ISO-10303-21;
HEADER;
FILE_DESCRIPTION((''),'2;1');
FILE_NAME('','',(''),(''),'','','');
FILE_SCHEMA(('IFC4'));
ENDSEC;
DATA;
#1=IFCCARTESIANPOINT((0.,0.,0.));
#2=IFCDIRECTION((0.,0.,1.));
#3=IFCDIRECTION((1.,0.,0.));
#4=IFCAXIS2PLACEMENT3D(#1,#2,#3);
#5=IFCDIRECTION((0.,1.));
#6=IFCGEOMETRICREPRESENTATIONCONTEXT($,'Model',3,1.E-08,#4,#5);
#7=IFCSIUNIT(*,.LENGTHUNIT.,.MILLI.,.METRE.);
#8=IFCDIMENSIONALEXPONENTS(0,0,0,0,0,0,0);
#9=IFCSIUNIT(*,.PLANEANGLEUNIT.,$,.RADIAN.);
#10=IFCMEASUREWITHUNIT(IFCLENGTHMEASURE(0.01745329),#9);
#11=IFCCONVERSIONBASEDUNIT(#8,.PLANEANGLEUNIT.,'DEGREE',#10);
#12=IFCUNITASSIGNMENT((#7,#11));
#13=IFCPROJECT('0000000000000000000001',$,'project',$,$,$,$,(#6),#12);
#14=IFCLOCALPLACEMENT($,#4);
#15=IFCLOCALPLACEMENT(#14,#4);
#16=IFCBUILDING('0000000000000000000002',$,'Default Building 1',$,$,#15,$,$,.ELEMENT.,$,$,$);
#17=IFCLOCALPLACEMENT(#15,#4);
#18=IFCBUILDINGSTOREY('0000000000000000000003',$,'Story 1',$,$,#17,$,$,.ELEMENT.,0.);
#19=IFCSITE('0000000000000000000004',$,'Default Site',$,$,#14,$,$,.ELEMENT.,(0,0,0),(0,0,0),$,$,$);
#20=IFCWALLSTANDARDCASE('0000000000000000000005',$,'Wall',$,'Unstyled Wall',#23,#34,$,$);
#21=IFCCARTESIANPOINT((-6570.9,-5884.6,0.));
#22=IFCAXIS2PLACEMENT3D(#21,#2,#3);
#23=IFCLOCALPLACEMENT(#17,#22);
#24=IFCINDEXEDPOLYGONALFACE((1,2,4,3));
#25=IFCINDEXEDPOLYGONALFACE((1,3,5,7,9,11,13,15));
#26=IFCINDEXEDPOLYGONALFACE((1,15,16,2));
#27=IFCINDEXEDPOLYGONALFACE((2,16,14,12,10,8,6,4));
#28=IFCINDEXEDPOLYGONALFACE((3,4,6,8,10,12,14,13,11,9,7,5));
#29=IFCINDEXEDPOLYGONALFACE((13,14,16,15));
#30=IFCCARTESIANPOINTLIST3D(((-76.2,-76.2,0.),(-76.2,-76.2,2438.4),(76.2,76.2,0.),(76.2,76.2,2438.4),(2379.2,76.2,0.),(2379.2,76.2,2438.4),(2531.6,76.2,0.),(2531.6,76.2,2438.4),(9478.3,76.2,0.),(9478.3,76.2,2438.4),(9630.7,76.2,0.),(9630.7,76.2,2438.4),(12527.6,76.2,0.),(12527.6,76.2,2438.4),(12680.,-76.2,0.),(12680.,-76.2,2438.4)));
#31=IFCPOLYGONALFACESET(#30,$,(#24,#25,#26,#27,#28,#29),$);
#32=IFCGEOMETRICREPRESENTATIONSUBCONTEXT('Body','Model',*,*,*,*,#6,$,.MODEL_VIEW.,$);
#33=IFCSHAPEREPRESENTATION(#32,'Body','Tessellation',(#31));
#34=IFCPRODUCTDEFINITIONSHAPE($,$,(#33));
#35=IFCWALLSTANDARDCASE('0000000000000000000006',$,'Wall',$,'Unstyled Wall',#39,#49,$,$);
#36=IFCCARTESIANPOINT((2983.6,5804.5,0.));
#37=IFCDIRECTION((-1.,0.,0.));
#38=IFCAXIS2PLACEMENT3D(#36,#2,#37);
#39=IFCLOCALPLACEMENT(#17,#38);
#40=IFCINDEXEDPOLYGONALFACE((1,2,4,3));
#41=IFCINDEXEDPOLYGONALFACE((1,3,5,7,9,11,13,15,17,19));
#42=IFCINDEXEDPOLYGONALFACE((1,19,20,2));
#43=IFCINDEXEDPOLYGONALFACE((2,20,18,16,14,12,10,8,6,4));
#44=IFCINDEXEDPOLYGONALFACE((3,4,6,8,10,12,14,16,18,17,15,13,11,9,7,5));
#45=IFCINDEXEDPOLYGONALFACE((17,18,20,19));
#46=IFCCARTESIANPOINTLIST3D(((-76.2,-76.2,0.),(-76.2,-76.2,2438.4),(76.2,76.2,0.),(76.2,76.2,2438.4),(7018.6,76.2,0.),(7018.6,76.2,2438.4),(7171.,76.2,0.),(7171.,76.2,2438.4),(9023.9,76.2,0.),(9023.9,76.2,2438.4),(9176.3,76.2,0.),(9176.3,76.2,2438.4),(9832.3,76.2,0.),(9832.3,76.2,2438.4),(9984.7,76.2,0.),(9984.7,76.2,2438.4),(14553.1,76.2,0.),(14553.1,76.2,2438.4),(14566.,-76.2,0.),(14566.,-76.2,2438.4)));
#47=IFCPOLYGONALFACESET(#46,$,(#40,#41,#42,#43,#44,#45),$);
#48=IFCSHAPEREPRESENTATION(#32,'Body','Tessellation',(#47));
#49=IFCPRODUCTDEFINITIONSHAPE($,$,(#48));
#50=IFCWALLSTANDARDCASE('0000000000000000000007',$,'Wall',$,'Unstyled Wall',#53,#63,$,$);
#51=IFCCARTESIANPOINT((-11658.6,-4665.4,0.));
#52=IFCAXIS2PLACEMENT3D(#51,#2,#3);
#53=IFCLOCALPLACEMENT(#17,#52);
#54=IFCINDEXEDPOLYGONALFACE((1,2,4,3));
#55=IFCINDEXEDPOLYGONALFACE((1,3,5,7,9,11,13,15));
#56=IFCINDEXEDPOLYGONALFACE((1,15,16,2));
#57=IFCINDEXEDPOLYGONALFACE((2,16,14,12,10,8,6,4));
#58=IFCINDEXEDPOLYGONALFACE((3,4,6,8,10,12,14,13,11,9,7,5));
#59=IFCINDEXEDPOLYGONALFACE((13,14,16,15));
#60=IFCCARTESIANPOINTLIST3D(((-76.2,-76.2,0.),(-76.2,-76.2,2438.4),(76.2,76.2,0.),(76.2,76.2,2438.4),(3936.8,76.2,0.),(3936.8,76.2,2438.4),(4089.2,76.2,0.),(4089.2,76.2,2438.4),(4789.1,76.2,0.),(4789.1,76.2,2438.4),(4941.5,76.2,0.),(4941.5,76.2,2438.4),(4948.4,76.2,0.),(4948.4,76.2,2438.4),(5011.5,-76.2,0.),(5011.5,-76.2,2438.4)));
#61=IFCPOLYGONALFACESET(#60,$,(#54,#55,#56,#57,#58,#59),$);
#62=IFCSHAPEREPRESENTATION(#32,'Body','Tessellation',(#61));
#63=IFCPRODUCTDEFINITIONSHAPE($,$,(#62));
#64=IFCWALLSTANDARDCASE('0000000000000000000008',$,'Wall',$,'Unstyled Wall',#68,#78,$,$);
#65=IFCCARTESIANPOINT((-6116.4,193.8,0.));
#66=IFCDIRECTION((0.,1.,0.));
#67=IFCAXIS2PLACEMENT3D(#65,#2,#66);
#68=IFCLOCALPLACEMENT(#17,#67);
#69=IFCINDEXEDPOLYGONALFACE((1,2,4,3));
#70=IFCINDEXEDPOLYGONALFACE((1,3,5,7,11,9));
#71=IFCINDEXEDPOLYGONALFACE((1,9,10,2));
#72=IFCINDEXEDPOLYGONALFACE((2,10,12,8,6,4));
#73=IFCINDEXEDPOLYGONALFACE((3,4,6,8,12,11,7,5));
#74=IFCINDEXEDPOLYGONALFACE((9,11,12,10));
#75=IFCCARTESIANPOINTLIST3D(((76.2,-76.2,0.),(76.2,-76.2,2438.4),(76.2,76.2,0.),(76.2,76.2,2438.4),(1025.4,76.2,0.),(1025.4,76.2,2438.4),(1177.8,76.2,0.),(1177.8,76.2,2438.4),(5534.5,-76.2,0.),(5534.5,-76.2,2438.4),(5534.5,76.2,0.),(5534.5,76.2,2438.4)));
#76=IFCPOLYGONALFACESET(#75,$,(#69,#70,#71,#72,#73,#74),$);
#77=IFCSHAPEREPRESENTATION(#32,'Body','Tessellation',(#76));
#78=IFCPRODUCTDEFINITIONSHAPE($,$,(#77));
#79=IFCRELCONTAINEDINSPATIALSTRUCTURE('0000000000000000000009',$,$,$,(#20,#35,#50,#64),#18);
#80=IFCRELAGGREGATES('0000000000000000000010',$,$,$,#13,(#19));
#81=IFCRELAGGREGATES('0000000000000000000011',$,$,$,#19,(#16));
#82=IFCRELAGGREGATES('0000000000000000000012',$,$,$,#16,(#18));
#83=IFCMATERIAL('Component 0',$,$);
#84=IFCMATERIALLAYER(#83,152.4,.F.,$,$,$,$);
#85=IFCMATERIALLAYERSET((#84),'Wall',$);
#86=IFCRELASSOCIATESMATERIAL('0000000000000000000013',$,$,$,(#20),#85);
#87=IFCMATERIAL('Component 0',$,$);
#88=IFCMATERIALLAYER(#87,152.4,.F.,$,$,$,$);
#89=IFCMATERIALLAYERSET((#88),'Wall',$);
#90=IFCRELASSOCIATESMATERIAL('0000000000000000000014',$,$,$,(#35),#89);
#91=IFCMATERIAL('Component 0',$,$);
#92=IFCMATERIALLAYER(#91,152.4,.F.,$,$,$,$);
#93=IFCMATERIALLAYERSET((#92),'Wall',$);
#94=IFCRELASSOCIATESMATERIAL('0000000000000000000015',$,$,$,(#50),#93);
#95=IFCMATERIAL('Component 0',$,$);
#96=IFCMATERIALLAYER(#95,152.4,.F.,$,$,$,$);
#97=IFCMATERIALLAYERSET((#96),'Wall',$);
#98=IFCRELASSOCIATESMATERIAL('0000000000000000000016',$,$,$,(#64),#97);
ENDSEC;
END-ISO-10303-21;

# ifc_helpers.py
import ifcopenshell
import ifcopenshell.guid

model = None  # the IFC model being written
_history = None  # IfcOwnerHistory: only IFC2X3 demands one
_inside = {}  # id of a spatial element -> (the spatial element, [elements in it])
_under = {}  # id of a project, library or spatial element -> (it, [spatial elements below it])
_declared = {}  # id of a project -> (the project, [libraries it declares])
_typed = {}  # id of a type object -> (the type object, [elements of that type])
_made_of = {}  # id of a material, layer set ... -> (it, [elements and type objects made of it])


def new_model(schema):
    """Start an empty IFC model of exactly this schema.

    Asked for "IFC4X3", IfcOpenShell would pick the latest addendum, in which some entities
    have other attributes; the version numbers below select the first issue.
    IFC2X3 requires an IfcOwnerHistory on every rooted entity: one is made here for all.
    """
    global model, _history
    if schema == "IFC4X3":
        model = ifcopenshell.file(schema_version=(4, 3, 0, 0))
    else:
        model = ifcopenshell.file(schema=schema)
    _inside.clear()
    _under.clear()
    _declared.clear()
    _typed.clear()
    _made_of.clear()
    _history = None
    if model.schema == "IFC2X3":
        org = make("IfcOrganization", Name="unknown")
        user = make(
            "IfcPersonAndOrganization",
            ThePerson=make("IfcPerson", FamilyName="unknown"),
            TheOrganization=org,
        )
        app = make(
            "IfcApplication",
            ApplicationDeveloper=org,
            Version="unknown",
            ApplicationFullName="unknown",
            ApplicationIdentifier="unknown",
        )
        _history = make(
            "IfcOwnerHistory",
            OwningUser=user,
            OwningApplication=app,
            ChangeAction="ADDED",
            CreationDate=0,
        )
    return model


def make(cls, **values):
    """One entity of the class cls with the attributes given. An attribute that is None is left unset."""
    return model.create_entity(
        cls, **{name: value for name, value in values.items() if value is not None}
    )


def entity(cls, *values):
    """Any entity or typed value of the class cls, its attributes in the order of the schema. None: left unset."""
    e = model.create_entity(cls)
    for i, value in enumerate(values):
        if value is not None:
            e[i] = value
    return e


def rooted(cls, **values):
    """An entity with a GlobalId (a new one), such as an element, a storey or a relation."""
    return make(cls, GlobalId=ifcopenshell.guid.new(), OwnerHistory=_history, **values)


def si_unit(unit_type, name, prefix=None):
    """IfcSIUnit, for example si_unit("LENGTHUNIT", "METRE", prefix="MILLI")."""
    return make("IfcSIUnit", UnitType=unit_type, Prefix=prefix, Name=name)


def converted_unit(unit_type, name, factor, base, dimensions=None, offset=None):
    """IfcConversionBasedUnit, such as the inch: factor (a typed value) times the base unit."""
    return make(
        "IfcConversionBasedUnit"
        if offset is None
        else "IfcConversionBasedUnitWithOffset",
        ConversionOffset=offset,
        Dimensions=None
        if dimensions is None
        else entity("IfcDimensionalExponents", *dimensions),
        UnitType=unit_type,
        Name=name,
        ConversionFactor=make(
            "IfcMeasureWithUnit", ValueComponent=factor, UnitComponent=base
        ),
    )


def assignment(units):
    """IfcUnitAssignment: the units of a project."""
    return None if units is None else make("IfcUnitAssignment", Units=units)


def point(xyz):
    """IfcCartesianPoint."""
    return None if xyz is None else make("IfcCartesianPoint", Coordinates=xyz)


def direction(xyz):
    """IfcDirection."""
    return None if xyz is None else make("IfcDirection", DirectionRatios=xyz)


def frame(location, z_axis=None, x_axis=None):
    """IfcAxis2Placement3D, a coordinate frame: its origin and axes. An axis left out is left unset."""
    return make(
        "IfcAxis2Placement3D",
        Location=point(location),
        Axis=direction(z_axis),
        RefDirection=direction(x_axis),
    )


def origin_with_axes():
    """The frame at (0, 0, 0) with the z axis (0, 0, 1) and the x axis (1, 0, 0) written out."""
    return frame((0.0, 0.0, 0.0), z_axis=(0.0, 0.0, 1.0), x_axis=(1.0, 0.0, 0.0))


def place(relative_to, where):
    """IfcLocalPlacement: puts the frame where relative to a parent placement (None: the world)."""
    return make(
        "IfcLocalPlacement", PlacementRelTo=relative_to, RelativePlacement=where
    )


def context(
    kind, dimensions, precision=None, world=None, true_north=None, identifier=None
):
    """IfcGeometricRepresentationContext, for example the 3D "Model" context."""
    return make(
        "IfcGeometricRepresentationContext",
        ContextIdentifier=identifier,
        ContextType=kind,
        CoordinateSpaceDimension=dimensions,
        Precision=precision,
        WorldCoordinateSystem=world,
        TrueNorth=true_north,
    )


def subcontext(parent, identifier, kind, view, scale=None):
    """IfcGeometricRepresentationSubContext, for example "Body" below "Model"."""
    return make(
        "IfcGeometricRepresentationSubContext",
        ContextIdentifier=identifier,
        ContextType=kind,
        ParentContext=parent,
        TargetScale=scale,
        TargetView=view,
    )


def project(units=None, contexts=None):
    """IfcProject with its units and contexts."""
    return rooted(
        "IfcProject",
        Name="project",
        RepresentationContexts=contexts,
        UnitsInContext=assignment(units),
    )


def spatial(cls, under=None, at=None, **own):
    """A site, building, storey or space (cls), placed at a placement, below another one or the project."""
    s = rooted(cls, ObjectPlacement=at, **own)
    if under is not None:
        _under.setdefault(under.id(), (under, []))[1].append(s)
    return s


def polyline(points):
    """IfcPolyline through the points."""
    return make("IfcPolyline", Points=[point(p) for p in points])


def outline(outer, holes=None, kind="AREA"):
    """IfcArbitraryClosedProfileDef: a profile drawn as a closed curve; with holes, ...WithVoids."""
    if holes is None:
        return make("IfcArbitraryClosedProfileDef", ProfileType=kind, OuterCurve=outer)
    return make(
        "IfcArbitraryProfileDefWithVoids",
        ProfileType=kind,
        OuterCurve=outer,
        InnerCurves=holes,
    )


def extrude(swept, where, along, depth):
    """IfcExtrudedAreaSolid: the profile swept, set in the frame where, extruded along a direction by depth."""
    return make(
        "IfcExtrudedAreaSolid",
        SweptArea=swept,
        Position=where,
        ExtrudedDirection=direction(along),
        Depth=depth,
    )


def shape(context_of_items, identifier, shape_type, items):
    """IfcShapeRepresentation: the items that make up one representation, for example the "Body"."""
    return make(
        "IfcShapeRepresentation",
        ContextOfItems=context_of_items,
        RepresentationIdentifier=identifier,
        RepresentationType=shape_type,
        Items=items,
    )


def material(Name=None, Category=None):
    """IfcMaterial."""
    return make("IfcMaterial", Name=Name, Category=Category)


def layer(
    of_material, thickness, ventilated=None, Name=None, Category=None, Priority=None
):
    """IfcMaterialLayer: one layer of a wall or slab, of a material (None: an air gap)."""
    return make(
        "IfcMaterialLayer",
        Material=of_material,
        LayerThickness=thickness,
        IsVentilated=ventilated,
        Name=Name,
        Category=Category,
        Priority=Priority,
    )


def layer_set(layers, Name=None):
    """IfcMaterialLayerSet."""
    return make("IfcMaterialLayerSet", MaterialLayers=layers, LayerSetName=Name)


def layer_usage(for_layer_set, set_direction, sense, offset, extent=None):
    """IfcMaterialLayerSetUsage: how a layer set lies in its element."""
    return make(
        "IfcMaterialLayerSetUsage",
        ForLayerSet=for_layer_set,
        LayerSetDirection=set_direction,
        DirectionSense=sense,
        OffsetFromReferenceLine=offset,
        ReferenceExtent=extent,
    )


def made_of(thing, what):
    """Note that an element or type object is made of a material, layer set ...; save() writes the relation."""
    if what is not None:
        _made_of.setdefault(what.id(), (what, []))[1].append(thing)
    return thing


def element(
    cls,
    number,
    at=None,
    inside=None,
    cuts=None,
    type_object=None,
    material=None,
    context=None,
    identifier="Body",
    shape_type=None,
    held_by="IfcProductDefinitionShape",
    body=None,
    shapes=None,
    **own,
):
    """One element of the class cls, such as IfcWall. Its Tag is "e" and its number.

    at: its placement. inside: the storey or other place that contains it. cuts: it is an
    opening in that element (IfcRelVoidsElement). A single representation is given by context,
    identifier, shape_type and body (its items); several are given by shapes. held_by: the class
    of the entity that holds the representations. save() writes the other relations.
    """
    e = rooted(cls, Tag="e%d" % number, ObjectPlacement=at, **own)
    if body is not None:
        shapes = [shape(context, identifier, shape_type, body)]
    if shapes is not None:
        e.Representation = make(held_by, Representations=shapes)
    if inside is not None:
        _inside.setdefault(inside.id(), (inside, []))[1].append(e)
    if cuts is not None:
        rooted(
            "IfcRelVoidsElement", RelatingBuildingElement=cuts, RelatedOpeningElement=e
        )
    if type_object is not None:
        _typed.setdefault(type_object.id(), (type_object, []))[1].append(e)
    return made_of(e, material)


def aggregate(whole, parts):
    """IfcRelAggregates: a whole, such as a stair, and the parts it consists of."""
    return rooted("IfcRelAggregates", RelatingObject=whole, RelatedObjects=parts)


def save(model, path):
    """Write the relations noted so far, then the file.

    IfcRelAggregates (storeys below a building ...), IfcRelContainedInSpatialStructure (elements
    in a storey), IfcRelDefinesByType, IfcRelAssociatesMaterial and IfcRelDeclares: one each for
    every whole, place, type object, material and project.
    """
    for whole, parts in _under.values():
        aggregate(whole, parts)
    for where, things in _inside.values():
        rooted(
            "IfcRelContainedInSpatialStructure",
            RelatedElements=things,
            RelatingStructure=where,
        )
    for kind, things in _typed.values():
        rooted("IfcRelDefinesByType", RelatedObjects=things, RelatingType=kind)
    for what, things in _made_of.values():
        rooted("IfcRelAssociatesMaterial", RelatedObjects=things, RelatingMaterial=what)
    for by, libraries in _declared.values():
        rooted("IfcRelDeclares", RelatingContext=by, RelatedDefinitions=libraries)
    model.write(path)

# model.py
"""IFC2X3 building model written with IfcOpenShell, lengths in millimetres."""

from ifc_helpers import new_model, entity, si_unit, converted_unit, direction, frame, origin_with_axes, place, context, subcontext, project, spatial, polyline, outline, extrude, material, layer, layer_set, layer_usage, element, save


model = new_model("IFC2X3")

# Units and contexts
model_context = context("Model", 3, precision=1e-08, world=origin_with_axes(), true_north=direction((0.0, 1.0)))
body_context = subcontext(model_context, "Body", "Model", "MODEL_VIEW")
ifc_project = project(units=[si_unit("LENGTHUNIT", "METRE", prefix="MILLI"), converted_unit("PLANEANGLEUNIT", "DEGREE", entity("IfcLengthMeasure", 0.01745329), si_unit("PLANEANGLEUNIT", "RADIAN"), dimensions=[0, 0, 0, 0, 0, 0, 0])], contexts=[model_context])

# Site, building, storey
site_placement = place(None, origin_with_axes())
site = spatial("IfcSite", under=ifc_project, at=site_placement, Name="Default Site", CompositionType="ELEMENT", RefLatitude=(0, 0, 0), RefLongitude=(0, 0, 0))
building_placement = place(site_placement, origin_with_axes())
building = spatial("IfcBuilding", under=site, at=building_placement, Name="Default Building 1", CompositionType="ELEMENT")
storey_placement = place(building_placement, origin_with_axes())
storey = spatial("IfcBuildingStorey", under=building, at=storey_placement, Name="Story 1", CompositionType="ELEMENT", Elevation=0.0)

# Walls
ifc_material_1 = material(Name="Component 0")
ifc_layer_1 = layer(ifc_material_1, 152.4, ventilated=False)
ifc_layer_set_1 = layer_set([ifc_layer_1], Name="Wall")
ifc_layer_usage_1 = layer_usage(ifc_layer_set_1, "AXIS2", "POSITIVE", -76.2)
wall_1_placement = place(storey_placement, frame((-6570.9, -5884.6, 0.0), z_axis=(0.0, 0.0, 1.0), x_axis=(1.0, 0.0, 0.0)))
element("IfcWallStandardCase", 1, at=wall_1_placement, inside=storey, material=ifc_layer_usage_1, Name="Wall", ObjectType="Unstyled Wall", context=body_context, shape_type="SweptSolid", body=[
    extrude(outline(polyline([(76.2, 76.2), (-76.2, -76.2), (12680.0, -76.2), (12527.6, 76.2), (9630.7, 76.2), (9478.3, 76.2), (2531.6, 76.2), (2379.2, 76.2), (76.2, 76.2)])), origin_with_axes(), (0.0, 0.0, 1.0), 2438.4),
])
ifc_material_2 = material(Name="Component 0")
ifc_layer_2 = layer(ifc_material_2, 152.4, ventilated=False)
ifc_layer_set_2 = layer_set([ifc_layer_2], Name="Wall")
ifc_layer_usage_2 = layer_usage(ifc_layer_set_2, "AXIS2", "POSITIVE", -76.2)
wall_2_placement = place(storey_placement, frame((2983.6, 5804.5, 0.0), z_axis=(0.0, 0.0, 1.0), x_axis=(-1.0, 0.0, 0.0)))
element("IfcWallStandardCase", 2, at=wall_2_placement, inside=storey, material=ifc_layer_usage_2, Name="Wall", ObjectType="Unstyled Wall", context=body_context, shape_type="SweptSolid", body=[
    extrude(outline(polyline([(76.2, 76.2), (-76.2, -76.2), (14566.0, -76.2), (14553.1, 76.2), (9984.7, 76.2), (9832.3, 76.2), (9176.3, 76.2), (9023.9, 76.2), (7171.0, 76.2), (7018.6, 76.2), (76.2, 76.2)])), origin_with_axes(), (0.0, 0.0, 1.0), 2438.4),
])
ifc_material_3 = material(Name="Component 0")
ifc_layer_3 = layer(ifc_material_3, 152.4, ventilated=False)
ifc_layer_set_3 = layer_set([ifc_layer_3], Name="Wall")
ifc_layer_usage_3 = layer_usage(ifc_layer_set_3, "AXIS2", "POSITIVE", -76.2)
wall_3_placement = place(storey_placement, frame((-11658.6, -4665.4, 0.0), z_axis=(0.0, 0.0, 1.0), x_axis=(1.0, 0.0, 0.0)))
element("IfcWallStandardCase", 3, at=wall_3_placement, inside=storey, material=ifc_layer_usage_3, Name="Wall", ObjectType="Unstyled Wall", context=body_context, shape_type="SweptSolid", body=[
    extrude(outline(polyline([(76.2, 76.2), (-76.2, -76.2), (5011.5, -76.2), (4948.4, 76.2), (4941.5, 76.2), (4789.1, 76.2), (4089.2, 76.2), (3936.8, 76.2), (76.2, 76.2)])), origin_with_axes(), (0.0, 0.0, 1.0), 2438.4),
])
ifc_material_4 = material(Name="Component 0")
ifc_layer_4 = layer(ifc_material_4, 152.4, ventilated=False)
ifc_layer_set_4 = layer_set([ifc_layer_4], Name="Wall")
ifc_layer_usage_4 = layer_usage(ifc_layer_set_4, "AXIS2", "POSITIVE", -76.2)
wall_4_placement = place(storey_placement, frame((-6116.4, 193.8, 0.0), z_axis=(0.0, 0.0, 1.0), x_axis=(0.0, 1.0, 0.0)))
element("IfcWallStandardCase", 4, at=wall_4_placement, inside=storey, material=ifc_layer_usage_4, Name="Wall", ObjectType="Unstyled Wall", context=body_context, shape_type="SweptSolid", body=[
    extrude(outline(polyline([(76.2, 76.2), (76.2, -76.2), (5534.5, -76.2), (5534.5, 76.2), (1177.8, 76.2), (1025.4, 76.2), (76.2, 76.2)])), origin_with_axes(), (0.0, 0.0, 1.0), 2438.4),
])

save(model, "model.ifc")
